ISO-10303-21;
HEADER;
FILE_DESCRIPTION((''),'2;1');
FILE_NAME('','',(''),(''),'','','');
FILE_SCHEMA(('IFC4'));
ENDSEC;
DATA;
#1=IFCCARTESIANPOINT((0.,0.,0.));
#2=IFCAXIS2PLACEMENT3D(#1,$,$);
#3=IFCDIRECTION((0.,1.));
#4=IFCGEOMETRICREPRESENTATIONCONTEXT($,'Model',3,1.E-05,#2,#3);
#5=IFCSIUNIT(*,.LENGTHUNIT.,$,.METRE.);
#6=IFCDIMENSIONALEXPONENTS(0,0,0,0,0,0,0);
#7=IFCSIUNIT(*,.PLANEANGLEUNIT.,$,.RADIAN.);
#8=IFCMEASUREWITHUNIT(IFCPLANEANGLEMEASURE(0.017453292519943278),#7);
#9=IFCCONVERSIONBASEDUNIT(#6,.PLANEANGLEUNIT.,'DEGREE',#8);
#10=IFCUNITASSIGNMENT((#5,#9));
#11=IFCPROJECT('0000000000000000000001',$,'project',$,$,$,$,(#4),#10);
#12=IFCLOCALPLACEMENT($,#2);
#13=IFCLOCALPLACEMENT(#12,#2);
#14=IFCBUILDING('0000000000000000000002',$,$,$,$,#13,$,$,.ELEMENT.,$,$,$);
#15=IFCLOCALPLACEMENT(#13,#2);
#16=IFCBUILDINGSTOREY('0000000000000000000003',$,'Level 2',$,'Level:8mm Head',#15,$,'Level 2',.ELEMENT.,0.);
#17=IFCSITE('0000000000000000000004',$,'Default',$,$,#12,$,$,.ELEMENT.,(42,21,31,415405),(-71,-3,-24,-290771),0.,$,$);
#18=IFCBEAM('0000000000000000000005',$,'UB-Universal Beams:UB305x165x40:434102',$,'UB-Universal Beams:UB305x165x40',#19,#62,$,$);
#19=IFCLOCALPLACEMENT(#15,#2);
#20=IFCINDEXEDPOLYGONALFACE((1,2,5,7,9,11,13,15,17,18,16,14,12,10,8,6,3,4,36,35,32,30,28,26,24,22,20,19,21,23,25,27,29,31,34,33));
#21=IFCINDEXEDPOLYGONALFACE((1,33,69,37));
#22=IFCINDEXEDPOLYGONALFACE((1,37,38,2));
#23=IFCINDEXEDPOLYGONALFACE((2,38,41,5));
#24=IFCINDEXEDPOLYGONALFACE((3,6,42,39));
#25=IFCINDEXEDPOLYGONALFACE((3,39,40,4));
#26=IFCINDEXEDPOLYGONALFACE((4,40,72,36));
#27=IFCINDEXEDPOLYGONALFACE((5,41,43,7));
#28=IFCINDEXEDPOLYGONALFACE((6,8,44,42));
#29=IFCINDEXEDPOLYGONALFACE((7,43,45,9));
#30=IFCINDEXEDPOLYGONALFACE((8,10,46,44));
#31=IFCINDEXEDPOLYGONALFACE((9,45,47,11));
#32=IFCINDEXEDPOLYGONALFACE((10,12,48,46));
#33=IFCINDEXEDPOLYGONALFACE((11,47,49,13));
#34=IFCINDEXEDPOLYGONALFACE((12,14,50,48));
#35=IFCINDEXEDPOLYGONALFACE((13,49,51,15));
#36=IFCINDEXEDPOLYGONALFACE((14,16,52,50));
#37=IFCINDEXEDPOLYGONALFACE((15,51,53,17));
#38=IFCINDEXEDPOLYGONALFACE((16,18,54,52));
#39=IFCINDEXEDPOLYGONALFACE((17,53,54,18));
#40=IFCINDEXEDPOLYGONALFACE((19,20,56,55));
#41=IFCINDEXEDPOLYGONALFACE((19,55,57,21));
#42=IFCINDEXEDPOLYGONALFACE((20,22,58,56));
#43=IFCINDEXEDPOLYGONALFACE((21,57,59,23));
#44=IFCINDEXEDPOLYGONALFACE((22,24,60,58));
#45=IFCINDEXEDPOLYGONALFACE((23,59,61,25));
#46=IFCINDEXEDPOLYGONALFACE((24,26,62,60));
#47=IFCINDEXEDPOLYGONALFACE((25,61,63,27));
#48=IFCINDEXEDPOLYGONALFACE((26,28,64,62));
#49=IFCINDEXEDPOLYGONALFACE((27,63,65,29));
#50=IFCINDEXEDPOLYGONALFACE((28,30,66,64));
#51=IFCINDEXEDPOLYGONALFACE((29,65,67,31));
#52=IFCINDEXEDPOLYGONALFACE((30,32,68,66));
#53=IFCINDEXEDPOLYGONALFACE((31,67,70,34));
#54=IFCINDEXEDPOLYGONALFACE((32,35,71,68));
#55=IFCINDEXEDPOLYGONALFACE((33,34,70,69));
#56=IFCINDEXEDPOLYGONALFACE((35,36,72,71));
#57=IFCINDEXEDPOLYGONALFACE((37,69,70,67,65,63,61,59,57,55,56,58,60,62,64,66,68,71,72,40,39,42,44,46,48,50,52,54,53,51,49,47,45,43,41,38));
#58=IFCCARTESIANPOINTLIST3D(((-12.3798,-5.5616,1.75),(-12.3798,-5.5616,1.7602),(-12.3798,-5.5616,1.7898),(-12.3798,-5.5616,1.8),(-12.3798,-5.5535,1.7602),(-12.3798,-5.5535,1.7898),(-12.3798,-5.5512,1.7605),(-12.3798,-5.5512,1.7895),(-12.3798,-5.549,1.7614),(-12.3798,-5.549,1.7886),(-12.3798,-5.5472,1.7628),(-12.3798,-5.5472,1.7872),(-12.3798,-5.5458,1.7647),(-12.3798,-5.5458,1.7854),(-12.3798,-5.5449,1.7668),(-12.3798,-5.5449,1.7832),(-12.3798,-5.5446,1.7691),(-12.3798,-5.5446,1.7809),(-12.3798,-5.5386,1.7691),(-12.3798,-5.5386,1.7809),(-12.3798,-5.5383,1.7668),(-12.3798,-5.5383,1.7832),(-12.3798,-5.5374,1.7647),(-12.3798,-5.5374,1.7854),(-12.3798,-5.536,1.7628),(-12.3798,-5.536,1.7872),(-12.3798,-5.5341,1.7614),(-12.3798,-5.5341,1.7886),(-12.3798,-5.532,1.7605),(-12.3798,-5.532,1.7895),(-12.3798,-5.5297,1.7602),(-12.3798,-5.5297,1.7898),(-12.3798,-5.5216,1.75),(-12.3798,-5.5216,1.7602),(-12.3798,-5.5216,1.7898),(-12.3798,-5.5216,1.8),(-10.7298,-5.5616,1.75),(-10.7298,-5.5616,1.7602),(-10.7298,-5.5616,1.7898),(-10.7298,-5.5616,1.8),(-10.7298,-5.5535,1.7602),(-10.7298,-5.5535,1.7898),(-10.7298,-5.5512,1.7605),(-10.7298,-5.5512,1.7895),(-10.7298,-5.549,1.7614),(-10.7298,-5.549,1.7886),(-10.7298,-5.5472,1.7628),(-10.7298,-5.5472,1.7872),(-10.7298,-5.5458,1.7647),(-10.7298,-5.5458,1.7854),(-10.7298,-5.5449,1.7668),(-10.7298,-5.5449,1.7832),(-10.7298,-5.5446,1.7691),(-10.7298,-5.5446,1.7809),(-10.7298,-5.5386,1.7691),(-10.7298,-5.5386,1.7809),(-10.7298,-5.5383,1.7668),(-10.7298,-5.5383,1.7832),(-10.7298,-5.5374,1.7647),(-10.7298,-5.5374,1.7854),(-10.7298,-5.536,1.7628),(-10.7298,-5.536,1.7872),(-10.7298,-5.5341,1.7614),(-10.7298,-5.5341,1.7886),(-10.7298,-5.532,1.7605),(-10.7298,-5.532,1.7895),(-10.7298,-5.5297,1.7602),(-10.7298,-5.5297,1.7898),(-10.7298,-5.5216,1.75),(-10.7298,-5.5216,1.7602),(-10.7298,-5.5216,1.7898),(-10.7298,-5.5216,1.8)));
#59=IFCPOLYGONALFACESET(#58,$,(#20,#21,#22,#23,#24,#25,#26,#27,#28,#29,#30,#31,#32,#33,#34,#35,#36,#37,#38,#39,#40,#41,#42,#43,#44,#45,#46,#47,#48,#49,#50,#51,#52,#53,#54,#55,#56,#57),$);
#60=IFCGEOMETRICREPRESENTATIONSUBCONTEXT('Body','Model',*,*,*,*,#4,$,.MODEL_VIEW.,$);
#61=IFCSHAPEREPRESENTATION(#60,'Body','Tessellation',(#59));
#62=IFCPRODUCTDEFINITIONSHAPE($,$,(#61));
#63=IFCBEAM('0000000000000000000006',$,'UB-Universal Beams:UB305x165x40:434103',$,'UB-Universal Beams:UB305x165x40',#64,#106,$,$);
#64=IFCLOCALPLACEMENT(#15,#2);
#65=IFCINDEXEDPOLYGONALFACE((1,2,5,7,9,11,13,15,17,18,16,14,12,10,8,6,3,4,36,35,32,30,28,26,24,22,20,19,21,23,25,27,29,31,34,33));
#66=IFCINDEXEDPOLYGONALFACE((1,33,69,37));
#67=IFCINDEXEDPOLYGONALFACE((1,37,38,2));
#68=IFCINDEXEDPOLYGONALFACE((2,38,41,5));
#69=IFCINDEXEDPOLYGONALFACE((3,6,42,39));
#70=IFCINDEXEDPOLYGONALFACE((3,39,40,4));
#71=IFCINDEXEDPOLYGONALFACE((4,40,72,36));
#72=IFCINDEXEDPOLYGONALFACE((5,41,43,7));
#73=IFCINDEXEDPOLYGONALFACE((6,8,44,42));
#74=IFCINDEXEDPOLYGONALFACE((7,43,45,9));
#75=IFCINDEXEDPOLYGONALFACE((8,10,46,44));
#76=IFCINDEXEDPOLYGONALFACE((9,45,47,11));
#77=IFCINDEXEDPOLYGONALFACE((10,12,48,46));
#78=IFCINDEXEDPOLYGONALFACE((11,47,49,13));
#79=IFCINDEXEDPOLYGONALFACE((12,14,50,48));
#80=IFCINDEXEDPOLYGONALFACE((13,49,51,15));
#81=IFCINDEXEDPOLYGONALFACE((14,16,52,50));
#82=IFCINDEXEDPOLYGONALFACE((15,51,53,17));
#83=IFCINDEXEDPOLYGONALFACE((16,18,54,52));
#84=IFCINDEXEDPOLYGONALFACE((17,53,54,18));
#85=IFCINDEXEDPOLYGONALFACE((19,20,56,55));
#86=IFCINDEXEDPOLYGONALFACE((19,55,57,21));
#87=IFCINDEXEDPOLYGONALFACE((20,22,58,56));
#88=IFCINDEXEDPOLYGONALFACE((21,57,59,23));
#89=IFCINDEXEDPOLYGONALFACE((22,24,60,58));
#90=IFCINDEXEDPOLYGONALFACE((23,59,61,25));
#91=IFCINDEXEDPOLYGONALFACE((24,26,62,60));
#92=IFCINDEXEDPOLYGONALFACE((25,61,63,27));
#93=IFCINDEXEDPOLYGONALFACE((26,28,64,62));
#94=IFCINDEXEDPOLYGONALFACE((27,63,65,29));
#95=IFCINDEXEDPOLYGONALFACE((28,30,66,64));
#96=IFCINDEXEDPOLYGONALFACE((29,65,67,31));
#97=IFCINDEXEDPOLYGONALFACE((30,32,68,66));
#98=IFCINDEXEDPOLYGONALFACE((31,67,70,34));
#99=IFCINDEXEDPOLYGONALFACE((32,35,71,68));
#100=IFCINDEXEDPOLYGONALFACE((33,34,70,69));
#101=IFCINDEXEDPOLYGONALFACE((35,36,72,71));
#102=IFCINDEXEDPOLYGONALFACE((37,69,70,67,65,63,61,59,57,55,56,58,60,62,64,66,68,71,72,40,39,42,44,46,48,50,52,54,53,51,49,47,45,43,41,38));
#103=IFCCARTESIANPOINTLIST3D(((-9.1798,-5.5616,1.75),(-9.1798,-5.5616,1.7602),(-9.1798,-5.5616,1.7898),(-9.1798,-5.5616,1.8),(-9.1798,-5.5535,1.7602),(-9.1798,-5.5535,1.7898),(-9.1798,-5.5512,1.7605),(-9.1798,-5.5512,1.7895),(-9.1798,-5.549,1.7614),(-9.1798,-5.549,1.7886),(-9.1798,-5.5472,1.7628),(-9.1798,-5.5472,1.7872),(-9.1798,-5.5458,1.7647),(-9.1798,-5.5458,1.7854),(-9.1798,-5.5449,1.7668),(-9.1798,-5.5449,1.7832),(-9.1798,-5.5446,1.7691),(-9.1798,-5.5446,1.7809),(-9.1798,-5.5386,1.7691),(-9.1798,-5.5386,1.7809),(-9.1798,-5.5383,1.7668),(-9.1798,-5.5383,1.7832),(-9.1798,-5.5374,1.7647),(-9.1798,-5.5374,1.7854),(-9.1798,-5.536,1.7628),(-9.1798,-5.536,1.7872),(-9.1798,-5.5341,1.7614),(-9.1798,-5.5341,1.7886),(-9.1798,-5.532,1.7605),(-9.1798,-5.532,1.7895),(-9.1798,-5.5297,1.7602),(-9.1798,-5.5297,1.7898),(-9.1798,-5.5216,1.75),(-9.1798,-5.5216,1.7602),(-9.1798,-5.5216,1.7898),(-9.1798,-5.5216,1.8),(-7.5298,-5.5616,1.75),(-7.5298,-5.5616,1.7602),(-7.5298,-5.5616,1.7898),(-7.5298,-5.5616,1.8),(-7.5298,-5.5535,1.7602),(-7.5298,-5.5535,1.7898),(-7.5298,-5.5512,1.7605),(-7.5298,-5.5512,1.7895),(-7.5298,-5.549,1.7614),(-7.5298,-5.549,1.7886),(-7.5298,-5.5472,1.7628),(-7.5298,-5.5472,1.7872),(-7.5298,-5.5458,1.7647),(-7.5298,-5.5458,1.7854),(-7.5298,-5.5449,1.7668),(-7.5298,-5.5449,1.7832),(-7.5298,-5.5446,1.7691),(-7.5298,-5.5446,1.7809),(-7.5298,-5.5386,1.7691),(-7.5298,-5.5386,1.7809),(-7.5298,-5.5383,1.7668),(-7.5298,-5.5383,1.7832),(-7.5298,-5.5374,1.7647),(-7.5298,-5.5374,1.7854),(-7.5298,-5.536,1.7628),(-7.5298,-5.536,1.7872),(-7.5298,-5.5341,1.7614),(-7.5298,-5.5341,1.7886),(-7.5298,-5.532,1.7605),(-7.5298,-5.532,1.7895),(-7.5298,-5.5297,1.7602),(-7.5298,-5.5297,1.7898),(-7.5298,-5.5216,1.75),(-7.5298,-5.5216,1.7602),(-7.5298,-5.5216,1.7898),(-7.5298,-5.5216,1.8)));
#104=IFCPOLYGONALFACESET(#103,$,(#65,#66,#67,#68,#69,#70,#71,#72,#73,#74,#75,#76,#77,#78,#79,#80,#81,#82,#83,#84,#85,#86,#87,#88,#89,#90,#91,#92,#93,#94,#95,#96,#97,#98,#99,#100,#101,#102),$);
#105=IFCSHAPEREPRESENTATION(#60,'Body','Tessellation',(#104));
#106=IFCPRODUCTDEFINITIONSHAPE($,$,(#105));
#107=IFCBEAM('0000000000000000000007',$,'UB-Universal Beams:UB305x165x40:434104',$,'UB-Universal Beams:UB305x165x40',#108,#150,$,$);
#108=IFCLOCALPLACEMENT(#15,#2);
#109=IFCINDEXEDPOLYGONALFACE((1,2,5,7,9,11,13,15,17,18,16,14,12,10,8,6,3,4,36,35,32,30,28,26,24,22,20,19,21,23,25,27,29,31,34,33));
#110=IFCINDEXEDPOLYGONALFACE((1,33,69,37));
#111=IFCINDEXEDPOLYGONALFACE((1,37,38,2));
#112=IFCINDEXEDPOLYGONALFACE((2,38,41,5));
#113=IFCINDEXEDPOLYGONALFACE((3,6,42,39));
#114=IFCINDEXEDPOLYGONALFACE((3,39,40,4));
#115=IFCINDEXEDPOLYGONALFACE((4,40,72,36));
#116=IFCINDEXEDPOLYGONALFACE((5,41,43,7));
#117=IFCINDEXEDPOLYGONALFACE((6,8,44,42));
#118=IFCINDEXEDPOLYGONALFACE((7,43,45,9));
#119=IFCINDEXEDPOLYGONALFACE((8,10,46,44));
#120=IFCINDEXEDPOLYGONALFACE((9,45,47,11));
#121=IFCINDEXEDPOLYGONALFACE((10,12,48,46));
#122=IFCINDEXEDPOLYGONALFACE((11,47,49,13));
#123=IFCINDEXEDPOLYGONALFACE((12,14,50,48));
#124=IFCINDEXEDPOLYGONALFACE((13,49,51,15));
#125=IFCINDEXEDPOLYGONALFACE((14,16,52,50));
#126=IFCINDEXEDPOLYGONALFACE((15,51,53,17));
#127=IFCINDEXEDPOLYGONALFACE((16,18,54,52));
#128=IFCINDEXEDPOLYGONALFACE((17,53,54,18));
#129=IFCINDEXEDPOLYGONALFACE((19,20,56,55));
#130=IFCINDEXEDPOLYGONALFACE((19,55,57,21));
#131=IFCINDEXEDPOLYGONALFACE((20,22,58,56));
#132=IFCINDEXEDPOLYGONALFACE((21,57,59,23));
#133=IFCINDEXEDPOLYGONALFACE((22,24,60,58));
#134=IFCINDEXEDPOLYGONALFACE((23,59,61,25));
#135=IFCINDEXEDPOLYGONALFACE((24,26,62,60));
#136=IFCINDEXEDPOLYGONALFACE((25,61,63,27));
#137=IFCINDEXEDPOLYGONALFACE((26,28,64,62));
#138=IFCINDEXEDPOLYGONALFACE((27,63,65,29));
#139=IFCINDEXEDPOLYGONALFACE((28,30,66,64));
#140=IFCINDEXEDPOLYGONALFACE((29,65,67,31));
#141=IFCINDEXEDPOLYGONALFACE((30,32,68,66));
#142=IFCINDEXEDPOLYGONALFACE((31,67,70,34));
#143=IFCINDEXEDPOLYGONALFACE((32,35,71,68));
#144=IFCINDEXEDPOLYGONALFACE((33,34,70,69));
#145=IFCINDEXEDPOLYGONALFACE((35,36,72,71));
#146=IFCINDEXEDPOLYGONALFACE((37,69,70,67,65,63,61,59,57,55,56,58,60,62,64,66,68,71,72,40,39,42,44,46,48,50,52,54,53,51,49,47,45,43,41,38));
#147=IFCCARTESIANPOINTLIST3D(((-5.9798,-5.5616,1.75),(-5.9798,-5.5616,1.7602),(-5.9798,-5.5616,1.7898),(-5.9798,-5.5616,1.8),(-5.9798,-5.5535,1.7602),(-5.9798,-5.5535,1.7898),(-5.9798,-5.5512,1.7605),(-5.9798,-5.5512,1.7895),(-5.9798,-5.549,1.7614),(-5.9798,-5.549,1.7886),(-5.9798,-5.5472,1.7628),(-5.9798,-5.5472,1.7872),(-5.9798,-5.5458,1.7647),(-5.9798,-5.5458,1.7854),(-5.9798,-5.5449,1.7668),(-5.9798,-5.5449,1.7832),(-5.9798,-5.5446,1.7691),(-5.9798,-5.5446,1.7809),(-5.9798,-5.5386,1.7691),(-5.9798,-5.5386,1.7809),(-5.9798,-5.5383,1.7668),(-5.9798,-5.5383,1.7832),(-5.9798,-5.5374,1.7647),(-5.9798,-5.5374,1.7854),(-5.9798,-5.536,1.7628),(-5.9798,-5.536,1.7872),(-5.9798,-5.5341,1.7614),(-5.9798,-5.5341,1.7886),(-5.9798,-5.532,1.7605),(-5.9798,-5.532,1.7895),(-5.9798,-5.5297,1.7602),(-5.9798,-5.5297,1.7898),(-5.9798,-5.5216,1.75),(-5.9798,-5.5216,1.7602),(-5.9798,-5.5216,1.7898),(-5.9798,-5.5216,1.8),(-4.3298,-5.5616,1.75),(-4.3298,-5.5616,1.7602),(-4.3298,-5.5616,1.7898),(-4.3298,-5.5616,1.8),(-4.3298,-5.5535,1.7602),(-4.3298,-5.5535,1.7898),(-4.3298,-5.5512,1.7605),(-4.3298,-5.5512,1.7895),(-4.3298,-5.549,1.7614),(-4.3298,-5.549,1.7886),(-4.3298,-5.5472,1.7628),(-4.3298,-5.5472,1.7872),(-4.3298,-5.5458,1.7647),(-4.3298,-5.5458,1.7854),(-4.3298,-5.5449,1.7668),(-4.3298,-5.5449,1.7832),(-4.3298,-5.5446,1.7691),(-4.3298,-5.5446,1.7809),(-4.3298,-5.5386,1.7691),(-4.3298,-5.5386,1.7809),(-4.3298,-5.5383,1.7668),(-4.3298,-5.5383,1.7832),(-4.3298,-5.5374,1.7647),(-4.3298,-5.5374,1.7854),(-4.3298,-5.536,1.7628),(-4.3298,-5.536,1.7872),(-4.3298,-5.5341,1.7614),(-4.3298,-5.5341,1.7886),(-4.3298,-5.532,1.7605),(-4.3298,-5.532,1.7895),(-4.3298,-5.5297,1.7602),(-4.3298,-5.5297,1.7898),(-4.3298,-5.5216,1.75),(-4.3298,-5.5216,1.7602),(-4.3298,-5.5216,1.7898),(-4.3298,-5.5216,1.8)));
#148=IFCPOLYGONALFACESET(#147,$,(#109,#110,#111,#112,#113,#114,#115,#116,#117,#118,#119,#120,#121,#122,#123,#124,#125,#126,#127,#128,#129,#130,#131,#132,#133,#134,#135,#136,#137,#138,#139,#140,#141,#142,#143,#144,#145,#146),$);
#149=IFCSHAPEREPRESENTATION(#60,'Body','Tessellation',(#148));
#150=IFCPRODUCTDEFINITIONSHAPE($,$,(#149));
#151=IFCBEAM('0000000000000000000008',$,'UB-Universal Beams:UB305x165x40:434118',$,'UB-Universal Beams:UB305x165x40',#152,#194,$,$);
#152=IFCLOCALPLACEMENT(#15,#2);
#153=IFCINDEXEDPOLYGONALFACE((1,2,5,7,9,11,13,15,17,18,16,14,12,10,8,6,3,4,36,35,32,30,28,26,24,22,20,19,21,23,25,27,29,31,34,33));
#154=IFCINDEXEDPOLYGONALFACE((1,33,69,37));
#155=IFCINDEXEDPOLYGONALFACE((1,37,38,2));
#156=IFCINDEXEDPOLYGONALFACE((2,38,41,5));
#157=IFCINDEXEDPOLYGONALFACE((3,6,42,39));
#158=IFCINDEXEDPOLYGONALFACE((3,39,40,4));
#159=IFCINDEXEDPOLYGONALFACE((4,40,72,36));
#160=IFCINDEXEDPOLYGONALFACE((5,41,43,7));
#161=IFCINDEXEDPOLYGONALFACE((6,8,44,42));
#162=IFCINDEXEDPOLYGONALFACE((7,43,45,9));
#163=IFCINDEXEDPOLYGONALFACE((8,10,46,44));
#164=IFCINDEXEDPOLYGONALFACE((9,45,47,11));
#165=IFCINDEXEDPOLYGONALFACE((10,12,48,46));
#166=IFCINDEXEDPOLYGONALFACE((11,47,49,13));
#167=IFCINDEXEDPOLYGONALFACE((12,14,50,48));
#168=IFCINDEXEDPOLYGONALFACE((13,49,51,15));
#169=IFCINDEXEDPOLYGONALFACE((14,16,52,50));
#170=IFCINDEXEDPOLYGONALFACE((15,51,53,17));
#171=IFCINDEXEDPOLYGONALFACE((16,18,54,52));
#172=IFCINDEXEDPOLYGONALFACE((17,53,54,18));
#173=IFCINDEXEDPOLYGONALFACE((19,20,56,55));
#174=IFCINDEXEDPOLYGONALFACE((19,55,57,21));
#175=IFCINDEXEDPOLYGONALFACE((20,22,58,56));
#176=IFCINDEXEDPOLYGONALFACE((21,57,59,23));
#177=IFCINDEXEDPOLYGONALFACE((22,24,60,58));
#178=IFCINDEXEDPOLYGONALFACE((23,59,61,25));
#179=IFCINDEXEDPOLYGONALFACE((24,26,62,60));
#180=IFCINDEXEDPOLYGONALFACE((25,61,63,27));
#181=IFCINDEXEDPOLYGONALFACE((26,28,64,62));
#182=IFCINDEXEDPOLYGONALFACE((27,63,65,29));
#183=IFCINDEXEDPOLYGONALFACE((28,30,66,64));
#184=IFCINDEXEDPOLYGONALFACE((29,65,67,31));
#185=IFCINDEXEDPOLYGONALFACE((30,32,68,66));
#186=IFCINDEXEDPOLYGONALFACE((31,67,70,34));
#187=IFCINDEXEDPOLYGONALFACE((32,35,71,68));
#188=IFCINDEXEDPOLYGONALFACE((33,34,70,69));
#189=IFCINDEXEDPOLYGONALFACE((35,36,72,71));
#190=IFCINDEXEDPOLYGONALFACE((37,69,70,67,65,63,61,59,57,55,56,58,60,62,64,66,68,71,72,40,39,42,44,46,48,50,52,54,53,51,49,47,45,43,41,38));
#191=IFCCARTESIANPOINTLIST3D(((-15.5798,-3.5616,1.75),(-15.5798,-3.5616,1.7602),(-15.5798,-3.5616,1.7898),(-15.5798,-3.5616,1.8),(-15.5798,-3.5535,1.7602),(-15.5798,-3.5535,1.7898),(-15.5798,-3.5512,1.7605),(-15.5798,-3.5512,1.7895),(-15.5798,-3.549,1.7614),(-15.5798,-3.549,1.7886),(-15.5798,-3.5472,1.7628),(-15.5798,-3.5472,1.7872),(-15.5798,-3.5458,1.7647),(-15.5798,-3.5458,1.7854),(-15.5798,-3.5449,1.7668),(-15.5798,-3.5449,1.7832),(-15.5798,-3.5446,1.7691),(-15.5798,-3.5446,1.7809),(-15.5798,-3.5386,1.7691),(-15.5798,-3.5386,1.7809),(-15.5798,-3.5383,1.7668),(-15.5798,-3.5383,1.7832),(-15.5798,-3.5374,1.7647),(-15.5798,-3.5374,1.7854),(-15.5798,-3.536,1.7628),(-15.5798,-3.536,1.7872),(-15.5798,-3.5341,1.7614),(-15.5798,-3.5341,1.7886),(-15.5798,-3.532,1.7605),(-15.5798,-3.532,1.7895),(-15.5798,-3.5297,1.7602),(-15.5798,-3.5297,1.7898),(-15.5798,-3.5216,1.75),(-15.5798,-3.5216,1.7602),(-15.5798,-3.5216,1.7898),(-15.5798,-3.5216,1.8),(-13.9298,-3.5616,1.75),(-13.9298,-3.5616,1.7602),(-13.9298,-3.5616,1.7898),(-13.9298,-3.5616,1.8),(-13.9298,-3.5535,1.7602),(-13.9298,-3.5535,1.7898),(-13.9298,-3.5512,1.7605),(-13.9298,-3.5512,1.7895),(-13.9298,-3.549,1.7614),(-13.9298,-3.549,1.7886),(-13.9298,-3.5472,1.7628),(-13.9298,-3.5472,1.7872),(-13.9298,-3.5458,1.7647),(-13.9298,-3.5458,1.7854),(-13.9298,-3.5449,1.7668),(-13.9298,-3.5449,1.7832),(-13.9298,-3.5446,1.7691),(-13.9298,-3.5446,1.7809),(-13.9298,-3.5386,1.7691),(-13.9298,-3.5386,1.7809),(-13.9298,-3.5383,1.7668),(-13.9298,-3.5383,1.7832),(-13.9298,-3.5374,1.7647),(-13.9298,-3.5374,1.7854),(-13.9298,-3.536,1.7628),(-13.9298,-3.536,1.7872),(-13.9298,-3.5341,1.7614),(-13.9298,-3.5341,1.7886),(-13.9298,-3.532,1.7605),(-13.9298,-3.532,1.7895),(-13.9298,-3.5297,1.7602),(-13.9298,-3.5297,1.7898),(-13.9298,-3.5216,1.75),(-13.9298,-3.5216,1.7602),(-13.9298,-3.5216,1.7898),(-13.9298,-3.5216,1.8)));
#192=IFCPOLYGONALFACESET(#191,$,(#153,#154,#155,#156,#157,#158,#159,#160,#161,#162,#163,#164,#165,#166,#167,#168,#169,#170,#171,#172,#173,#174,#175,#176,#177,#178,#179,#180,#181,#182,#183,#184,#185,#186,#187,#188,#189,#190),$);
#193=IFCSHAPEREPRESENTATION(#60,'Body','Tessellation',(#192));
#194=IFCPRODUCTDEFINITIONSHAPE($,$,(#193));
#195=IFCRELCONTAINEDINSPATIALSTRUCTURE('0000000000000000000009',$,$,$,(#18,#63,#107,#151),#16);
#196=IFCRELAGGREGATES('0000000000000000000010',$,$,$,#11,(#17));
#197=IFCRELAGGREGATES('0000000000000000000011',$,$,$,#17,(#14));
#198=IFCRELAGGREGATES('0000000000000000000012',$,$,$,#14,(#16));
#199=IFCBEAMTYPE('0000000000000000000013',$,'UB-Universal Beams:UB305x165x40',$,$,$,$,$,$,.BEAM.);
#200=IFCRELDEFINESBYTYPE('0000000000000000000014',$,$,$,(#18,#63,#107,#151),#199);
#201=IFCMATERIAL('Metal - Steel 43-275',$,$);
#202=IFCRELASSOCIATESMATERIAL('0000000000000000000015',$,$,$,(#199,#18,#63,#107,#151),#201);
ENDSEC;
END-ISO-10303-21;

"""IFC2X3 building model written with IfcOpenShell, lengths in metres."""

from ifc_helpers import new_model, entity, si_unit, converted_unit, direction, frame, frame_2d, origin, place, context, subcontext, project, spatial, i_section, extrude, material, type_object, element, save


model = new_model("IFC2X3")

# Units and contexts
model_context = context("Model", 3, precision=1e-05, world=origin(), true_north=direction((0.0, 1.0)))
body_context = subcontext(model_context, "Body", "Model", "MODEL_VIEW")
ifc_project = project(units=[si_unit("LENGTHUNIT", "METRE"), converted_unit("PLANEANGLEUNIT", "DEGREE", entity("IfcPlaneAngleMeasure", 0.017453292519943278), si_unit("PLANEANGLEUNIT", "RADIAN"), dimensions=[0, 0, 0, 0, 0, 0, 0])], contexts=[model_context])

# Site, building, storey
site_placement = place(None, origin())
site = spatial("IfcSite", under=ifc_project, at=site_placement, Name="Default", CompositionType="ELEMENT", RefLatitude=(42, 21, 31, 415405), RefLongitude=(-71, -3, -24, -290771), RefElevation=0.0)
building_placement = place(site_placement, origin())
building = spatial("IfcBuilding", under=site, at=building_placement, CompositionType="ELEMENT")
storey_placement = place(building_placement, origin())
storey = spatial("IfcBuildingStorey", under=building, at=storey_placement, Name="Level 2", ObjectType="Level:8mm Head", LongName="Level 2", CompositionType="ELEMENT", Elevation=0.0)

# Shared definitions
ifc_material = material(Name="Metal - Steel 43-275")

# Beams
beam_type = type_object("IfcBeamType", Name="UB-Universal Beams:UB305x165x40", PredefinedType="BEAM", material=ifc_material)
for number, where, name in (
    (1, (-12.3798, -5.5416, 1.8), "UB-Universal Beams:UB305x165x40:434102"),
):
    element("IfcBeam", number, at=place(storey_placement, frame(where)), inside=storey, type_object=beam_type, material=ifc_material, Name=name, ObjectType="UB-Universal Beams:UB305x165x40", context=body_context, shape_type="SweptSolid", body=[
        extrude(i_section(OverallWidth=0.04, OverallDepth=0.05, WebThickness=0.006, FlangeThickness=0.0102, FilletRadius=0.0089, at=frame_2d((0.0, 0.0), x_axis=(0.0, 1.0))), frame((0.0, 0.0, -0.025), z_axis=(1.0, 0.0, 0.0), x_axis=(0.0, 0.0, -1.0)), (0.0, 0.0, 1.0), 1.65),
    ])
for number, where, name in (
    (2, (-9.1798, -5.5416, 1.8), "UB-Universal Beams:UB305x165x40:434103"),
    (3, (-5.9798, -5.5416, 1.8), "UB-Universal Beams:UB305x165x40:434104"),
):
    element("IfcBeam", number, at=place(storey_placement, frame(where)), inside=storey, type_object=beam_type, material=ifc_material, Name=name, ObjectType="UB-Universal Beams:UB305x165x40", context=body_context, shape_type="SweptSolid", body=[
        extrude(i_section(OverallWidth=0.04, OverallDepth=0.05, WebThickness=0.006, FlangeThickness=0.0102, FilletRadius=0.0089, at=frame_2d((0.0, 0.0), x_axis=(0.0, 1.0))), frame((0.0, 0.0, -0.025), z_axis=(1.0, 0.0, 0.0), x_axis=(0.0, 0.0, -1.0)), (0.0, 0.0, 1.0), 1.65),
    ])
for number, where, name in (
    (4, (-15.5798, -3.5416, 1.8), "UB-Universal Beams:UB305x165x40:434118"),
):
    element("IfcBeam", number, at=place(storey_placement, frame(where)), inside=storey, type_object=beam_type, material=ifc_material, Name=name, ObjectType="UB-Universal Beams:UB305x165x40", context=body_context, shape_type="SweptSolid", body=[
        extrude(i_section(OverallWidth=0.04, OverallDepth=0.05, WebThickness=0.006, FlangeThickness=0.0102, FilletRadius=0.0089, at=frame_2d((0.0, 0.0), x_axis=(0.0, 1.0))), frame((0.0, 0.0, -0.025), z_axis=(1.0, 0.0, 0.0), x_axis=(0.0, 0.0, -1.0)), (0.0, 0.0, 1.0), 1.65),
    ])

save(model, "model.ifc")
